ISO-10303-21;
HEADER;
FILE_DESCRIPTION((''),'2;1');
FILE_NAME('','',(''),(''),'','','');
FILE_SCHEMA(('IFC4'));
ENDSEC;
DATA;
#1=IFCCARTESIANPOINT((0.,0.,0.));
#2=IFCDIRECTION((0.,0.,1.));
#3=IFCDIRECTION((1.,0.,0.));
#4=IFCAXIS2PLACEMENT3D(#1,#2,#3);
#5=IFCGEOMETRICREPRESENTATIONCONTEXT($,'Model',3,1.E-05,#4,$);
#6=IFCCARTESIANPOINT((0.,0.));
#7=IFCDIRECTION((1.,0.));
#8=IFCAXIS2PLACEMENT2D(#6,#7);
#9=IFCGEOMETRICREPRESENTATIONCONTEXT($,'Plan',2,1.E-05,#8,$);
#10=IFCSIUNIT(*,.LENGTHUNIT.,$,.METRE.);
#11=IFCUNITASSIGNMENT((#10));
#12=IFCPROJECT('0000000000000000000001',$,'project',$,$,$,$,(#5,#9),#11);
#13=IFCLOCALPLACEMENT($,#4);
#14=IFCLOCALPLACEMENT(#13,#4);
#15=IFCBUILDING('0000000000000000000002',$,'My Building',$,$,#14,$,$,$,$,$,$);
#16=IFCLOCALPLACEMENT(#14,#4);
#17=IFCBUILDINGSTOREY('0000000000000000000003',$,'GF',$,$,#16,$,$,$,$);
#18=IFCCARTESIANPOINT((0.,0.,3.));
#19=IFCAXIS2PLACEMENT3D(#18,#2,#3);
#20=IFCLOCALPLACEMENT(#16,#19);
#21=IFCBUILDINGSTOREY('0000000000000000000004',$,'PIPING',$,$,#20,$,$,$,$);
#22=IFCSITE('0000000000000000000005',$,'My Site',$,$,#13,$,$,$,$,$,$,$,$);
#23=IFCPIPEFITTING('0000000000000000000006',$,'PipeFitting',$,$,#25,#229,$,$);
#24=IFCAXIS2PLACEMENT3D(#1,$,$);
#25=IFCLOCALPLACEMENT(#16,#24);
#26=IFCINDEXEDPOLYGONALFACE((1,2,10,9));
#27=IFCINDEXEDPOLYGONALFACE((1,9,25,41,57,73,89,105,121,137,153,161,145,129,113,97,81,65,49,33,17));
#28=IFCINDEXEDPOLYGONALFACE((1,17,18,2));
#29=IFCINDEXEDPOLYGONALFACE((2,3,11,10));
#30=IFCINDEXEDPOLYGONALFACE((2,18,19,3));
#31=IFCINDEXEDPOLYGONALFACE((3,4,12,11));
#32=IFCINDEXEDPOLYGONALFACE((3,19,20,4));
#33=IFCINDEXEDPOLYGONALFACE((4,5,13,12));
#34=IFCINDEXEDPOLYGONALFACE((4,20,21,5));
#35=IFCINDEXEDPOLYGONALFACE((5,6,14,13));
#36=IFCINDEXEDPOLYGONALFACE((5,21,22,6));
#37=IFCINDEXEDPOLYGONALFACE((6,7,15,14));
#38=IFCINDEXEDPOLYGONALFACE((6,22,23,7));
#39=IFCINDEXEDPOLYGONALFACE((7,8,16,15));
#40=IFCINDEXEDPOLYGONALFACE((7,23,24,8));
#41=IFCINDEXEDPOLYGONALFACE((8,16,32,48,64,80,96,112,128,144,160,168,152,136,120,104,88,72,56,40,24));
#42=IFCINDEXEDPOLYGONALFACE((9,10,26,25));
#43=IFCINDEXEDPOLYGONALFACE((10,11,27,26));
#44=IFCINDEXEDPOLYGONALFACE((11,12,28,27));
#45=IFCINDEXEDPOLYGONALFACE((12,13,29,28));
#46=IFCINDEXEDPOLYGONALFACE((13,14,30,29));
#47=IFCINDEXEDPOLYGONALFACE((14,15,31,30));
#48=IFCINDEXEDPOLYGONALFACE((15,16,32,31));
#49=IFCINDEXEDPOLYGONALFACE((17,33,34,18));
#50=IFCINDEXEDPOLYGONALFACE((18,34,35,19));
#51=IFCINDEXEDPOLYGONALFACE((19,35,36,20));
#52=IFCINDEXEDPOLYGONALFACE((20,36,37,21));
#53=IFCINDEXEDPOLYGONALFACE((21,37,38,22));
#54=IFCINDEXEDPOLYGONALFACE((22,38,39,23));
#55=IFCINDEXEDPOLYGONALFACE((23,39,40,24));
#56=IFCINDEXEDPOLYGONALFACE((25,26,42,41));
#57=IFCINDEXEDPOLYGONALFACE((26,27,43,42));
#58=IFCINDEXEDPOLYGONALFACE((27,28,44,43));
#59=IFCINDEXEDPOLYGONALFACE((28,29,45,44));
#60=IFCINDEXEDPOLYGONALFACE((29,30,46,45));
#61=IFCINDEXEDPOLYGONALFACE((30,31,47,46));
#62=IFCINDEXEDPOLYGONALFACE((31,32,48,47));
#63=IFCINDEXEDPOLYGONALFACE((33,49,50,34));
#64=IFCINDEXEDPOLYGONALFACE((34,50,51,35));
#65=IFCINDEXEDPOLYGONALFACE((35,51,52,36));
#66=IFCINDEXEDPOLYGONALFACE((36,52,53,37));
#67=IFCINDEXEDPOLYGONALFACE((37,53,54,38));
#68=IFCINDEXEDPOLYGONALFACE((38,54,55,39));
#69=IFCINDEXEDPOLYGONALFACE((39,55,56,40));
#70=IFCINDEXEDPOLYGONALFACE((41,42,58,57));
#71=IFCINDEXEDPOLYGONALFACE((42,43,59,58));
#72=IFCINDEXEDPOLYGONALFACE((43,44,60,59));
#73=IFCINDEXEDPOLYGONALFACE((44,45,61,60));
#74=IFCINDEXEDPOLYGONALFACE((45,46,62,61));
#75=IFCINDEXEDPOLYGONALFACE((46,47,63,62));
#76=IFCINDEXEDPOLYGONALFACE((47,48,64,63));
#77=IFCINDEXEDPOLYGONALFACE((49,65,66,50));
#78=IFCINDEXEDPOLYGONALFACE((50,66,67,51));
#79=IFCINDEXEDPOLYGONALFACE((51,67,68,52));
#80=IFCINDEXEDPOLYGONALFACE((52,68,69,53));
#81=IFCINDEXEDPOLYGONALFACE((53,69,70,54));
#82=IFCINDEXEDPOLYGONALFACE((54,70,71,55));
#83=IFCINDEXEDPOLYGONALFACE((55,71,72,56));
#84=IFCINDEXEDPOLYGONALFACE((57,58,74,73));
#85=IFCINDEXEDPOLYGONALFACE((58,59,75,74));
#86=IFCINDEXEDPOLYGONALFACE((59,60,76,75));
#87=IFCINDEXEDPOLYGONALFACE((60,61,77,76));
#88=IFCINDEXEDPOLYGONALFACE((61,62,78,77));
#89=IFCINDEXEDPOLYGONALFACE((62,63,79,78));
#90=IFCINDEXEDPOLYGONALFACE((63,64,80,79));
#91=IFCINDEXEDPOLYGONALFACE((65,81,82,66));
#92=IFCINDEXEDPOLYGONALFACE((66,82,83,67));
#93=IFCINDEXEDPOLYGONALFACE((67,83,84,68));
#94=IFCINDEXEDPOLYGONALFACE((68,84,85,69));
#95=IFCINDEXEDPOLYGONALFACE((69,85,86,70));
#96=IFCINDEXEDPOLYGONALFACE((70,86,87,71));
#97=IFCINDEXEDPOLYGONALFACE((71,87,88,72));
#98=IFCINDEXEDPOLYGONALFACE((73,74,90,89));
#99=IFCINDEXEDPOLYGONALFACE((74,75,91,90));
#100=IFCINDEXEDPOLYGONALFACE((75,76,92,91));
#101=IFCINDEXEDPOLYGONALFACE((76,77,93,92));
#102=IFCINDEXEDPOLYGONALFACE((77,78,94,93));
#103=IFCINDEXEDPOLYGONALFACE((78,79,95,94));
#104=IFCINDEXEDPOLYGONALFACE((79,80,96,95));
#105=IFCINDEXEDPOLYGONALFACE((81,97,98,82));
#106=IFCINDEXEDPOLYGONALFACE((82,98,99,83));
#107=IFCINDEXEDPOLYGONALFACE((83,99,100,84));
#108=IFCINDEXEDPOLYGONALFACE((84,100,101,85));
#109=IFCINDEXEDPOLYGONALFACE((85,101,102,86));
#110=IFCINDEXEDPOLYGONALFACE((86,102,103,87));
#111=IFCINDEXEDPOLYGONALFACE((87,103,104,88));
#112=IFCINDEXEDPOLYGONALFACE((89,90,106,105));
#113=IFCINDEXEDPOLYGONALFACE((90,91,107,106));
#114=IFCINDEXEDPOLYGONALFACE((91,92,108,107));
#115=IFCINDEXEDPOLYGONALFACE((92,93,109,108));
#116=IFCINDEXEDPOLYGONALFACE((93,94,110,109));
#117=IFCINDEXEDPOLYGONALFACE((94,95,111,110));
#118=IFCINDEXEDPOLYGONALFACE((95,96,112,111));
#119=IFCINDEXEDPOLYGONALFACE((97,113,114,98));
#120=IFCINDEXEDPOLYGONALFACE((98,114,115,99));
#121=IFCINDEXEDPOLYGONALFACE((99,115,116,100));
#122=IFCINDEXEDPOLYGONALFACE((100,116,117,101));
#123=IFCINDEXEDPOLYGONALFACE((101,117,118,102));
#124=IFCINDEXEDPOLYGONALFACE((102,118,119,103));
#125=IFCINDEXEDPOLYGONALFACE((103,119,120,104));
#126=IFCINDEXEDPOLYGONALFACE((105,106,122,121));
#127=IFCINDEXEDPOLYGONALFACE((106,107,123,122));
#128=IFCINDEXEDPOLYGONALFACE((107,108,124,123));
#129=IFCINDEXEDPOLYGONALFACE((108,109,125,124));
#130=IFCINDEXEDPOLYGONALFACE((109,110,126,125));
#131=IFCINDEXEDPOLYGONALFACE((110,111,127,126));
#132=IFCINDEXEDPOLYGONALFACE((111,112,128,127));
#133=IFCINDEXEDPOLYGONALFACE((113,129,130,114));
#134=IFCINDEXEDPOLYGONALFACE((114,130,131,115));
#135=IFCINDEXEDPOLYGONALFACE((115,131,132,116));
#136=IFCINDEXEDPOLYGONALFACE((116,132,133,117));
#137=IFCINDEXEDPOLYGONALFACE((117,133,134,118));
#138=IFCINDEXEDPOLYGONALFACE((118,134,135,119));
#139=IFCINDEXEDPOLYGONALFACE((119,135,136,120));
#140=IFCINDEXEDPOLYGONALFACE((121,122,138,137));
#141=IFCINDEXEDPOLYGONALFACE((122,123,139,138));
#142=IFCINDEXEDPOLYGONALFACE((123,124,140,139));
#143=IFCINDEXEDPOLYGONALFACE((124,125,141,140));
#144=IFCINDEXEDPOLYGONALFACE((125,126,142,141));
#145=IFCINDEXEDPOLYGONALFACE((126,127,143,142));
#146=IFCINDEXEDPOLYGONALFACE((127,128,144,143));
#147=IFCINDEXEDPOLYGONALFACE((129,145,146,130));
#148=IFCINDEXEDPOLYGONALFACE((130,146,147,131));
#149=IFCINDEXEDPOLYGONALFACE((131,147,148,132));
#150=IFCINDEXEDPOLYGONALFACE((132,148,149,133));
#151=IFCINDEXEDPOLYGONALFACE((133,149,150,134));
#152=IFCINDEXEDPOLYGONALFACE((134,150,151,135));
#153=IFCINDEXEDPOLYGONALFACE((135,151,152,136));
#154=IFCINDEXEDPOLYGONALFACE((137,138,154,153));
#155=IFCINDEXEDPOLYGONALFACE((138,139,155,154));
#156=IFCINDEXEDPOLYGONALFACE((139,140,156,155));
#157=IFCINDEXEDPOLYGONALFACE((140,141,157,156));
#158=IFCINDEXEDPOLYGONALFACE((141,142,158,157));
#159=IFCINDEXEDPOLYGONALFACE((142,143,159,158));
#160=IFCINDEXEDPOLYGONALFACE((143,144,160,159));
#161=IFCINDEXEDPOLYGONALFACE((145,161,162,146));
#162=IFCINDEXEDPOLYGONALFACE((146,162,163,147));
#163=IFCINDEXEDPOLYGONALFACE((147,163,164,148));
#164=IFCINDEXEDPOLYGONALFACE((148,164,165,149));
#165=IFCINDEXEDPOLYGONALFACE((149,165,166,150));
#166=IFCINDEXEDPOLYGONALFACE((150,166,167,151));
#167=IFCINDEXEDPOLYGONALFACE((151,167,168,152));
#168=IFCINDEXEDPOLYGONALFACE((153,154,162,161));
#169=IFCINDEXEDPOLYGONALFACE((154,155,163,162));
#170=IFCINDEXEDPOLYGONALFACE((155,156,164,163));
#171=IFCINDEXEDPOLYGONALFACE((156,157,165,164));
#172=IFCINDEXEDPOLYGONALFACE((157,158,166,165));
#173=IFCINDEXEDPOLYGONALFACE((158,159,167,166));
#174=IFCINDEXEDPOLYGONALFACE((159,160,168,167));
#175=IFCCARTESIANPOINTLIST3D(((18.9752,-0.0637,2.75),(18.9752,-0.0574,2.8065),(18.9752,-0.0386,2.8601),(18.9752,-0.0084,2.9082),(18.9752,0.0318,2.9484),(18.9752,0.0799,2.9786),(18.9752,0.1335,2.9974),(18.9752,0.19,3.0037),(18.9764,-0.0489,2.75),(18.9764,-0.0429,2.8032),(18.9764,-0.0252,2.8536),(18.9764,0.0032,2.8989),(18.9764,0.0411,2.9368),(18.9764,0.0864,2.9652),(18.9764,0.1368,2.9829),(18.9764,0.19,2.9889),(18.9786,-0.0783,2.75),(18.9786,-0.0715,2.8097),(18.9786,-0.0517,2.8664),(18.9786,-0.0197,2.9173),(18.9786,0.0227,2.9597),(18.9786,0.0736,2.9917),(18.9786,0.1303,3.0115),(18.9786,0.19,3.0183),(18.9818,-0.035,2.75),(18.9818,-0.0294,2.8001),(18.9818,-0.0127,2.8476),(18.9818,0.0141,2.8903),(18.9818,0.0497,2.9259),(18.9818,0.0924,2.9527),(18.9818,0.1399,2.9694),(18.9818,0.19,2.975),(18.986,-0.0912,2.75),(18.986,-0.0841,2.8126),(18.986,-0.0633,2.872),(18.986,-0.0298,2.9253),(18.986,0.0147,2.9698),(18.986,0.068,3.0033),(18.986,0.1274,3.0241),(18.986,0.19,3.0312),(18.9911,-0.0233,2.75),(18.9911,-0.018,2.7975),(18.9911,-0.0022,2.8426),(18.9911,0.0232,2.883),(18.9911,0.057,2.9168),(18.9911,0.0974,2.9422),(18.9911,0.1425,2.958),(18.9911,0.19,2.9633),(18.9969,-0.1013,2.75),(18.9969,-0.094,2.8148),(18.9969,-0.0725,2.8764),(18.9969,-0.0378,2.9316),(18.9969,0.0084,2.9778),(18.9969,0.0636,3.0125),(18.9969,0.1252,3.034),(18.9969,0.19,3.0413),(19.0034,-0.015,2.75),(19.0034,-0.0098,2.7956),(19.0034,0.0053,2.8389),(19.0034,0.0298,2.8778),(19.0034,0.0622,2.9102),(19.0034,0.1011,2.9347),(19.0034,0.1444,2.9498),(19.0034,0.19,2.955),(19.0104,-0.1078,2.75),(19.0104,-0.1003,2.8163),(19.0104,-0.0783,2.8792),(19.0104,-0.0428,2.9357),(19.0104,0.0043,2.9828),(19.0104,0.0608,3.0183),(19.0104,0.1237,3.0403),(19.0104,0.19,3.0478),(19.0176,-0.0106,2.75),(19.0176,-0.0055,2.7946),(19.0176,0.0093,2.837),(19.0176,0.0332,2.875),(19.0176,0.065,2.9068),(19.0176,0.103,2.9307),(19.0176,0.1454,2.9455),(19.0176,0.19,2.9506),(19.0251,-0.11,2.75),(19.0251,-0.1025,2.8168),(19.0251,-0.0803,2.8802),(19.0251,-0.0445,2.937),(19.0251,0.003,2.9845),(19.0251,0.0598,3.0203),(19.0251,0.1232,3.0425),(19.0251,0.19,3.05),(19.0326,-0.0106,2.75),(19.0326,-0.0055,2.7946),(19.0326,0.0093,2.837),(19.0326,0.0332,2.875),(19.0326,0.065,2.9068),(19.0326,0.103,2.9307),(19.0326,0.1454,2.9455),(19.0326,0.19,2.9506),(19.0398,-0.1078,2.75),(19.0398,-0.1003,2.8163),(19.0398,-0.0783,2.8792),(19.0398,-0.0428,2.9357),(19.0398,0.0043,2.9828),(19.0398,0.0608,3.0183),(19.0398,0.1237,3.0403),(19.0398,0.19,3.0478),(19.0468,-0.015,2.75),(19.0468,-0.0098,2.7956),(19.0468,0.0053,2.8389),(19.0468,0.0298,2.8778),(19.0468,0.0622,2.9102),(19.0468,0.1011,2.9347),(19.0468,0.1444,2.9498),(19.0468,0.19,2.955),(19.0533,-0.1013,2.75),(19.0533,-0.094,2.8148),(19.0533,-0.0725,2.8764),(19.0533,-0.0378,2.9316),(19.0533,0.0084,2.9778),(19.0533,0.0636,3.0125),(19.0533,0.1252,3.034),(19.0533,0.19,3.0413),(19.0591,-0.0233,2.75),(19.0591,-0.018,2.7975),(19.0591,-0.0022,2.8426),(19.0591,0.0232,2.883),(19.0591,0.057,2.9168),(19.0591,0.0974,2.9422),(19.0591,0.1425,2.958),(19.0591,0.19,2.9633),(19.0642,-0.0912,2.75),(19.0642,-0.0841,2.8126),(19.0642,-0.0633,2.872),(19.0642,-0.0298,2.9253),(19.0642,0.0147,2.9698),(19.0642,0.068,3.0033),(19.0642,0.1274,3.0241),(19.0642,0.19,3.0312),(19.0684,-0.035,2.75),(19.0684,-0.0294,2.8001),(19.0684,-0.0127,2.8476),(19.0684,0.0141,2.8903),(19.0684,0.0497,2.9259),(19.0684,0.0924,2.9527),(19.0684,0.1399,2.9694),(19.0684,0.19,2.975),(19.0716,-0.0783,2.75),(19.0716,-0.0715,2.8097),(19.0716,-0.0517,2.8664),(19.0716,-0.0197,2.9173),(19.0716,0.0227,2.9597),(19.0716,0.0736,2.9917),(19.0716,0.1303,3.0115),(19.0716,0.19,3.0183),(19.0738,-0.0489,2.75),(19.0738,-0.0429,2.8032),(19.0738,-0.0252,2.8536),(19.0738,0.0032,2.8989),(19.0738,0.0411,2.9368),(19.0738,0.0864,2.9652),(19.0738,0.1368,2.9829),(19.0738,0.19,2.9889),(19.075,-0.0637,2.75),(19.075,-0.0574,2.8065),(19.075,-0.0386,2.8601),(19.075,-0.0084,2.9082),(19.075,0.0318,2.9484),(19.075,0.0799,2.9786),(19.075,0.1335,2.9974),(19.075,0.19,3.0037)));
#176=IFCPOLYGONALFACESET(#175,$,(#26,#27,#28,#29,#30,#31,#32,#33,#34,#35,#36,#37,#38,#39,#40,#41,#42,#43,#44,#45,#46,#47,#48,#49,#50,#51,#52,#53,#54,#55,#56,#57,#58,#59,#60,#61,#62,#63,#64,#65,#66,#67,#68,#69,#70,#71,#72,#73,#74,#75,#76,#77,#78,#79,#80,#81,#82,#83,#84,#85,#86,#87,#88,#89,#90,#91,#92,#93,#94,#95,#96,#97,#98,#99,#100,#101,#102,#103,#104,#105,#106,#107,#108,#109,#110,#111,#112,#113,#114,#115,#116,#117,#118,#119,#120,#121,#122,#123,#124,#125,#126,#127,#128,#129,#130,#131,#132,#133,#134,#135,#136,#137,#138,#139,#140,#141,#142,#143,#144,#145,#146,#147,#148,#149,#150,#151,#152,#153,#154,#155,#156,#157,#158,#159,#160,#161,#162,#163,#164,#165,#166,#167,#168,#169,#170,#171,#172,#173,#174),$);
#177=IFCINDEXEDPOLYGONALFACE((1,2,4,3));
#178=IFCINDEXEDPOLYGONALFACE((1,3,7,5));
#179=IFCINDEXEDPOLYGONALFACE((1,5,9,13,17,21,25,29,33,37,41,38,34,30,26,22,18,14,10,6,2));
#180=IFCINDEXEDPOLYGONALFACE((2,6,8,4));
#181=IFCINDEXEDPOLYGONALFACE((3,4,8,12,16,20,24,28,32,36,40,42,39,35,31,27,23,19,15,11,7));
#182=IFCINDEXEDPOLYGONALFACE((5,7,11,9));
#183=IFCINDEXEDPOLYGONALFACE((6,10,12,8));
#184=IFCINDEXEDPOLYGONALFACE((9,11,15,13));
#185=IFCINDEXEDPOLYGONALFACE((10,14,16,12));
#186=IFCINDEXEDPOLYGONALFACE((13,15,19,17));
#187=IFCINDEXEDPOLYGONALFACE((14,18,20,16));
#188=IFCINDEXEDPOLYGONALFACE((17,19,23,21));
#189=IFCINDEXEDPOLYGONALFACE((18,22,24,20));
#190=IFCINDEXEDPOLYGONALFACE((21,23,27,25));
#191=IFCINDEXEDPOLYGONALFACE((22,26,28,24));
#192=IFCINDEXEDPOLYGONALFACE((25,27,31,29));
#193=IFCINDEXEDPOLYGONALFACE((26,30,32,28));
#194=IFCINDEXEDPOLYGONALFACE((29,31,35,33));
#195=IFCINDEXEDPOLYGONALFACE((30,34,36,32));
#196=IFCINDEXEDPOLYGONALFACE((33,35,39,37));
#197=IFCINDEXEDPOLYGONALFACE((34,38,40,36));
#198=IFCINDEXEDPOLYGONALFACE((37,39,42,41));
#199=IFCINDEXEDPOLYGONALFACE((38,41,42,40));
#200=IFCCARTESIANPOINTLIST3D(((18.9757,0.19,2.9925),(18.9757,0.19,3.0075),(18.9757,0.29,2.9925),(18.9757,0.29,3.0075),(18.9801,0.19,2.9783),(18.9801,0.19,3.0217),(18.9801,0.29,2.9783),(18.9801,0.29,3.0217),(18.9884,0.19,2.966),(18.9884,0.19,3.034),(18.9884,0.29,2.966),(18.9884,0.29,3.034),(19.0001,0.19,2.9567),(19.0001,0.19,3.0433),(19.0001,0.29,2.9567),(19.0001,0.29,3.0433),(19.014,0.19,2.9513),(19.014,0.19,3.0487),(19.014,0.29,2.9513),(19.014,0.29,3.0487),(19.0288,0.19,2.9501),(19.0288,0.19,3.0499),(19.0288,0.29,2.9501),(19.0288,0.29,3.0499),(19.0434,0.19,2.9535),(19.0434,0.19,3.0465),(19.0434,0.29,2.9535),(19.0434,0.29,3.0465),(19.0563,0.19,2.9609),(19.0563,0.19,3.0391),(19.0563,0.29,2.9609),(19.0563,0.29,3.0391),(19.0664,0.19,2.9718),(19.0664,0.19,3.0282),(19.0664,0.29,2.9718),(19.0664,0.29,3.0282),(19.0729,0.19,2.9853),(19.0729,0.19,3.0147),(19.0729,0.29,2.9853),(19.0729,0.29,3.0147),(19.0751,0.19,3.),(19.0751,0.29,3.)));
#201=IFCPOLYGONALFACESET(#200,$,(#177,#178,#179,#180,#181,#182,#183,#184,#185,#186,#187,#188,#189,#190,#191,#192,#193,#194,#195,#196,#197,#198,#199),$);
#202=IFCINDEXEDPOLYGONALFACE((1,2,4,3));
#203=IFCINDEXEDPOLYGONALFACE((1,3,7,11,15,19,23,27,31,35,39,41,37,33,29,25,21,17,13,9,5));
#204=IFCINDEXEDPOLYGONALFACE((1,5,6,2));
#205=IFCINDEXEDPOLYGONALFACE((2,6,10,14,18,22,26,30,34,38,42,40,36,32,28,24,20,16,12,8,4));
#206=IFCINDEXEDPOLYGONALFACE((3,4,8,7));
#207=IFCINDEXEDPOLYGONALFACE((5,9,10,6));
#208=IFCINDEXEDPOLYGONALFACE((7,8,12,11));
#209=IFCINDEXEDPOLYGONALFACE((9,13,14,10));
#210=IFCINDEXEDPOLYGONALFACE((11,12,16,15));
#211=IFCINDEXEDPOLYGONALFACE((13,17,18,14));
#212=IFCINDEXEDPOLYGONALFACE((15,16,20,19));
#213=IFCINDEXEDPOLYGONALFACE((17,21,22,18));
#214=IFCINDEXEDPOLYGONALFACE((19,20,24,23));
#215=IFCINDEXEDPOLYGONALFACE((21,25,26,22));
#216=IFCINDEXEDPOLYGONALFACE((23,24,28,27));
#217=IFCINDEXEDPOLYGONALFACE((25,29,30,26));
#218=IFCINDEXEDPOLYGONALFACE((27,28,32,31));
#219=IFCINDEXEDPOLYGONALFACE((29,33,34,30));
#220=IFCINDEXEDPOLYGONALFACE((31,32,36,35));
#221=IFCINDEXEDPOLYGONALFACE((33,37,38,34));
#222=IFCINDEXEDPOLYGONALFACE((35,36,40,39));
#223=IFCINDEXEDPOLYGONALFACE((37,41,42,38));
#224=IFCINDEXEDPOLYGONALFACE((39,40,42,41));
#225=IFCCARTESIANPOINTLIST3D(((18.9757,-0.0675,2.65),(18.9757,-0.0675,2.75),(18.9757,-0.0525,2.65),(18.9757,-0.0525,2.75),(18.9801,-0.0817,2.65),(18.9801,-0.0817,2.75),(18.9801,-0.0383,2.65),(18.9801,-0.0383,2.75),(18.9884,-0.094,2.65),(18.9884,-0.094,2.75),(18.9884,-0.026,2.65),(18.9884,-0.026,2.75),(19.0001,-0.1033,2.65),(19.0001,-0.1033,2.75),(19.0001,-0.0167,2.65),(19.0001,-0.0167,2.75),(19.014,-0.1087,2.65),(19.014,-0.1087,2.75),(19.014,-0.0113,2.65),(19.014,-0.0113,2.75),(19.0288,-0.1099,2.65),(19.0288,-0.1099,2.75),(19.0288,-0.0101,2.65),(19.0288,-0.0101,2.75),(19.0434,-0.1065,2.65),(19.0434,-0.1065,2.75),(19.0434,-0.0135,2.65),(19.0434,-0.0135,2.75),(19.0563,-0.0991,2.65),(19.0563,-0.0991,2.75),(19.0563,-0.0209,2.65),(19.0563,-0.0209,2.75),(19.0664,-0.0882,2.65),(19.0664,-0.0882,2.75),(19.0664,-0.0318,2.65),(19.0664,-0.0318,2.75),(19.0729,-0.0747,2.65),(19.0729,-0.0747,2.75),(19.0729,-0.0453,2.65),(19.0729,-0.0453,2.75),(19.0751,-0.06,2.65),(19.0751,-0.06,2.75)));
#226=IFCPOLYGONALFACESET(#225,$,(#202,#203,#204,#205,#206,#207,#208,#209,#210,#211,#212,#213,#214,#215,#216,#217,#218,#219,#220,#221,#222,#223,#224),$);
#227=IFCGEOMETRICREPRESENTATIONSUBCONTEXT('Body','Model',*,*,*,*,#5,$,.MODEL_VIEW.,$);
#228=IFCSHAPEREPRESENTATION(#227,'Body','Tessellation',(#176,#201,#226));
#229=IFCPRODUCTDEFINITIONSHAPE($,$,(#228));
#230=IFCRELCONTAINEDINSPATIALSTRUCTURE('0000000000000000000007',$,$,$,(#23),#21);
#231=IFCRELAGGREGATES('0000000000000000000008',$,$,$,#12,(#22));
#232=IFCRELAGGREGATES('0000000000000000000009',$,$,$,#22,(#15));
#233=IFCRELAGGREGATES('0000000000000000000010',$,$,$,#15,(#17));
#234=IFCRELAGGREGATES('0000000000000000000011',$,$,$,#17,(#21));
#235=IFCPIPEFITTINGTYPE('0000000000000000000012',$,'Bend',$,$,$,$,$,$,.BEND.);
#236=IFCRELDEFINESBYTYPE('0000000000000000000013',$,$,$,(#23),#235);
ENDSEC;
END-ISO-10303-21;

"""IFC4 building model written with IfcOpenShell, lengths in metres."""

from ifc_helpers import new_model, entity, si_unit, frame, origin_with_axes, origin_2d_with_axis, place, context, subcontext, project, spatial, circle, extrude, source, transform, mapped, type_object, type_shapes, element, save


model = new_model("IFC4")

# Units and contexts
model_context = context("Model", 3, precision=1e-05, world=origin_with_axes())
plan_context = context("Plan", 2, precision=1e-05, world=origin_2d_with_axis())
body_context = subcontext(model_context, "Body", "Model", "MODEL_VIEW")
ifc_project = project(units=[si_unit("LENGTHUNIT", "METRE")], contexts=[model_context, plan_context])

# Site, building, storeys
site_placement = place(None, origin_with_axes())
site = spatial("IfcSite", under=ifc_project, at=site_placement, Name="My Site")
building_placement = place(site_placement, origin_with_axes())
building = spatial("IfcBuilding", under=site, at=building_placement, Name="My Building")
storey_1_placement = place(building_placement, origin_with_axes())
storey_1 = spatial("IfcBuildingStorey", under=building, at=storey_1_placement, Name="GF")
storey_2_placement = place(storey_1_placement, frame((0.0, 0.0, 3.0), z_axis=(0.0, 0.0, 1.0), x_axis=(1.0, 0.0, 0.0)))
storey_2 = spatial("IfcBuildingStorey", under=storey_1, at=storey_2_placement, Name="PIPING")

# Pipe fitting
pipe_fitting_type = type_object("IfcPipeFittingType", Name="Bend", PredefinedType="BEND")
shared_shape = source(origin_with_axes(), body_context, "Body", "SolidModel", [
    entity("IfcSweptDiskSolid", entity("IfcIndexedPolyCurve", entity("IfcCartesianPointList3D", [[0.0, 0.0, -0.1], [0.0, 0.0732, -0.2768], [0.0, 0.25, -0.35]]), [entity("IfcArcIndex", [1, 2, 3])]), 0.05),
    extrude(circle(Radius=0.05), origin_with_axes(), (0.0, 0.0, -1.0), 0.1),
    extrude(circle(Radius=0.05), frame((0.0, 0.25, -0.35), z_axis=(0.0, 1.0, 0.0), x_axis=(1.0, 0.0, 0.0)), (0.0, 0.0, 1.0), 0.1),
])
type_shapes(pipe_fitting_type, [shared_shape])
for number, where, z_axis, x_axis, name in (
    (1, (19.0251, 0.29, 0.0), (0.0, 1.0, 0.0), (1.0, 0.0, 0.0), "PipeFitting"),
):
    element("IfcPipeFitting", number, at=place(storey_2_placement, frame(where, z_axis=z_axis, x_axis=x_axis)), inside=storey_2, type_object=pipe_fitting_type, Name=name, context=body_context, shape_type="MappedRepresentation", body=[
        mapped(shared_shape, transform((0.0, 0.0, 0.0), x_axis=(1.0, 0.0, 0.0), y_axis=(0.0, 1.0, 0.0), z_axis=(0.0, 0.0, 1.0), scale=1.0)),
    ])

save(model, "model.ifc")
